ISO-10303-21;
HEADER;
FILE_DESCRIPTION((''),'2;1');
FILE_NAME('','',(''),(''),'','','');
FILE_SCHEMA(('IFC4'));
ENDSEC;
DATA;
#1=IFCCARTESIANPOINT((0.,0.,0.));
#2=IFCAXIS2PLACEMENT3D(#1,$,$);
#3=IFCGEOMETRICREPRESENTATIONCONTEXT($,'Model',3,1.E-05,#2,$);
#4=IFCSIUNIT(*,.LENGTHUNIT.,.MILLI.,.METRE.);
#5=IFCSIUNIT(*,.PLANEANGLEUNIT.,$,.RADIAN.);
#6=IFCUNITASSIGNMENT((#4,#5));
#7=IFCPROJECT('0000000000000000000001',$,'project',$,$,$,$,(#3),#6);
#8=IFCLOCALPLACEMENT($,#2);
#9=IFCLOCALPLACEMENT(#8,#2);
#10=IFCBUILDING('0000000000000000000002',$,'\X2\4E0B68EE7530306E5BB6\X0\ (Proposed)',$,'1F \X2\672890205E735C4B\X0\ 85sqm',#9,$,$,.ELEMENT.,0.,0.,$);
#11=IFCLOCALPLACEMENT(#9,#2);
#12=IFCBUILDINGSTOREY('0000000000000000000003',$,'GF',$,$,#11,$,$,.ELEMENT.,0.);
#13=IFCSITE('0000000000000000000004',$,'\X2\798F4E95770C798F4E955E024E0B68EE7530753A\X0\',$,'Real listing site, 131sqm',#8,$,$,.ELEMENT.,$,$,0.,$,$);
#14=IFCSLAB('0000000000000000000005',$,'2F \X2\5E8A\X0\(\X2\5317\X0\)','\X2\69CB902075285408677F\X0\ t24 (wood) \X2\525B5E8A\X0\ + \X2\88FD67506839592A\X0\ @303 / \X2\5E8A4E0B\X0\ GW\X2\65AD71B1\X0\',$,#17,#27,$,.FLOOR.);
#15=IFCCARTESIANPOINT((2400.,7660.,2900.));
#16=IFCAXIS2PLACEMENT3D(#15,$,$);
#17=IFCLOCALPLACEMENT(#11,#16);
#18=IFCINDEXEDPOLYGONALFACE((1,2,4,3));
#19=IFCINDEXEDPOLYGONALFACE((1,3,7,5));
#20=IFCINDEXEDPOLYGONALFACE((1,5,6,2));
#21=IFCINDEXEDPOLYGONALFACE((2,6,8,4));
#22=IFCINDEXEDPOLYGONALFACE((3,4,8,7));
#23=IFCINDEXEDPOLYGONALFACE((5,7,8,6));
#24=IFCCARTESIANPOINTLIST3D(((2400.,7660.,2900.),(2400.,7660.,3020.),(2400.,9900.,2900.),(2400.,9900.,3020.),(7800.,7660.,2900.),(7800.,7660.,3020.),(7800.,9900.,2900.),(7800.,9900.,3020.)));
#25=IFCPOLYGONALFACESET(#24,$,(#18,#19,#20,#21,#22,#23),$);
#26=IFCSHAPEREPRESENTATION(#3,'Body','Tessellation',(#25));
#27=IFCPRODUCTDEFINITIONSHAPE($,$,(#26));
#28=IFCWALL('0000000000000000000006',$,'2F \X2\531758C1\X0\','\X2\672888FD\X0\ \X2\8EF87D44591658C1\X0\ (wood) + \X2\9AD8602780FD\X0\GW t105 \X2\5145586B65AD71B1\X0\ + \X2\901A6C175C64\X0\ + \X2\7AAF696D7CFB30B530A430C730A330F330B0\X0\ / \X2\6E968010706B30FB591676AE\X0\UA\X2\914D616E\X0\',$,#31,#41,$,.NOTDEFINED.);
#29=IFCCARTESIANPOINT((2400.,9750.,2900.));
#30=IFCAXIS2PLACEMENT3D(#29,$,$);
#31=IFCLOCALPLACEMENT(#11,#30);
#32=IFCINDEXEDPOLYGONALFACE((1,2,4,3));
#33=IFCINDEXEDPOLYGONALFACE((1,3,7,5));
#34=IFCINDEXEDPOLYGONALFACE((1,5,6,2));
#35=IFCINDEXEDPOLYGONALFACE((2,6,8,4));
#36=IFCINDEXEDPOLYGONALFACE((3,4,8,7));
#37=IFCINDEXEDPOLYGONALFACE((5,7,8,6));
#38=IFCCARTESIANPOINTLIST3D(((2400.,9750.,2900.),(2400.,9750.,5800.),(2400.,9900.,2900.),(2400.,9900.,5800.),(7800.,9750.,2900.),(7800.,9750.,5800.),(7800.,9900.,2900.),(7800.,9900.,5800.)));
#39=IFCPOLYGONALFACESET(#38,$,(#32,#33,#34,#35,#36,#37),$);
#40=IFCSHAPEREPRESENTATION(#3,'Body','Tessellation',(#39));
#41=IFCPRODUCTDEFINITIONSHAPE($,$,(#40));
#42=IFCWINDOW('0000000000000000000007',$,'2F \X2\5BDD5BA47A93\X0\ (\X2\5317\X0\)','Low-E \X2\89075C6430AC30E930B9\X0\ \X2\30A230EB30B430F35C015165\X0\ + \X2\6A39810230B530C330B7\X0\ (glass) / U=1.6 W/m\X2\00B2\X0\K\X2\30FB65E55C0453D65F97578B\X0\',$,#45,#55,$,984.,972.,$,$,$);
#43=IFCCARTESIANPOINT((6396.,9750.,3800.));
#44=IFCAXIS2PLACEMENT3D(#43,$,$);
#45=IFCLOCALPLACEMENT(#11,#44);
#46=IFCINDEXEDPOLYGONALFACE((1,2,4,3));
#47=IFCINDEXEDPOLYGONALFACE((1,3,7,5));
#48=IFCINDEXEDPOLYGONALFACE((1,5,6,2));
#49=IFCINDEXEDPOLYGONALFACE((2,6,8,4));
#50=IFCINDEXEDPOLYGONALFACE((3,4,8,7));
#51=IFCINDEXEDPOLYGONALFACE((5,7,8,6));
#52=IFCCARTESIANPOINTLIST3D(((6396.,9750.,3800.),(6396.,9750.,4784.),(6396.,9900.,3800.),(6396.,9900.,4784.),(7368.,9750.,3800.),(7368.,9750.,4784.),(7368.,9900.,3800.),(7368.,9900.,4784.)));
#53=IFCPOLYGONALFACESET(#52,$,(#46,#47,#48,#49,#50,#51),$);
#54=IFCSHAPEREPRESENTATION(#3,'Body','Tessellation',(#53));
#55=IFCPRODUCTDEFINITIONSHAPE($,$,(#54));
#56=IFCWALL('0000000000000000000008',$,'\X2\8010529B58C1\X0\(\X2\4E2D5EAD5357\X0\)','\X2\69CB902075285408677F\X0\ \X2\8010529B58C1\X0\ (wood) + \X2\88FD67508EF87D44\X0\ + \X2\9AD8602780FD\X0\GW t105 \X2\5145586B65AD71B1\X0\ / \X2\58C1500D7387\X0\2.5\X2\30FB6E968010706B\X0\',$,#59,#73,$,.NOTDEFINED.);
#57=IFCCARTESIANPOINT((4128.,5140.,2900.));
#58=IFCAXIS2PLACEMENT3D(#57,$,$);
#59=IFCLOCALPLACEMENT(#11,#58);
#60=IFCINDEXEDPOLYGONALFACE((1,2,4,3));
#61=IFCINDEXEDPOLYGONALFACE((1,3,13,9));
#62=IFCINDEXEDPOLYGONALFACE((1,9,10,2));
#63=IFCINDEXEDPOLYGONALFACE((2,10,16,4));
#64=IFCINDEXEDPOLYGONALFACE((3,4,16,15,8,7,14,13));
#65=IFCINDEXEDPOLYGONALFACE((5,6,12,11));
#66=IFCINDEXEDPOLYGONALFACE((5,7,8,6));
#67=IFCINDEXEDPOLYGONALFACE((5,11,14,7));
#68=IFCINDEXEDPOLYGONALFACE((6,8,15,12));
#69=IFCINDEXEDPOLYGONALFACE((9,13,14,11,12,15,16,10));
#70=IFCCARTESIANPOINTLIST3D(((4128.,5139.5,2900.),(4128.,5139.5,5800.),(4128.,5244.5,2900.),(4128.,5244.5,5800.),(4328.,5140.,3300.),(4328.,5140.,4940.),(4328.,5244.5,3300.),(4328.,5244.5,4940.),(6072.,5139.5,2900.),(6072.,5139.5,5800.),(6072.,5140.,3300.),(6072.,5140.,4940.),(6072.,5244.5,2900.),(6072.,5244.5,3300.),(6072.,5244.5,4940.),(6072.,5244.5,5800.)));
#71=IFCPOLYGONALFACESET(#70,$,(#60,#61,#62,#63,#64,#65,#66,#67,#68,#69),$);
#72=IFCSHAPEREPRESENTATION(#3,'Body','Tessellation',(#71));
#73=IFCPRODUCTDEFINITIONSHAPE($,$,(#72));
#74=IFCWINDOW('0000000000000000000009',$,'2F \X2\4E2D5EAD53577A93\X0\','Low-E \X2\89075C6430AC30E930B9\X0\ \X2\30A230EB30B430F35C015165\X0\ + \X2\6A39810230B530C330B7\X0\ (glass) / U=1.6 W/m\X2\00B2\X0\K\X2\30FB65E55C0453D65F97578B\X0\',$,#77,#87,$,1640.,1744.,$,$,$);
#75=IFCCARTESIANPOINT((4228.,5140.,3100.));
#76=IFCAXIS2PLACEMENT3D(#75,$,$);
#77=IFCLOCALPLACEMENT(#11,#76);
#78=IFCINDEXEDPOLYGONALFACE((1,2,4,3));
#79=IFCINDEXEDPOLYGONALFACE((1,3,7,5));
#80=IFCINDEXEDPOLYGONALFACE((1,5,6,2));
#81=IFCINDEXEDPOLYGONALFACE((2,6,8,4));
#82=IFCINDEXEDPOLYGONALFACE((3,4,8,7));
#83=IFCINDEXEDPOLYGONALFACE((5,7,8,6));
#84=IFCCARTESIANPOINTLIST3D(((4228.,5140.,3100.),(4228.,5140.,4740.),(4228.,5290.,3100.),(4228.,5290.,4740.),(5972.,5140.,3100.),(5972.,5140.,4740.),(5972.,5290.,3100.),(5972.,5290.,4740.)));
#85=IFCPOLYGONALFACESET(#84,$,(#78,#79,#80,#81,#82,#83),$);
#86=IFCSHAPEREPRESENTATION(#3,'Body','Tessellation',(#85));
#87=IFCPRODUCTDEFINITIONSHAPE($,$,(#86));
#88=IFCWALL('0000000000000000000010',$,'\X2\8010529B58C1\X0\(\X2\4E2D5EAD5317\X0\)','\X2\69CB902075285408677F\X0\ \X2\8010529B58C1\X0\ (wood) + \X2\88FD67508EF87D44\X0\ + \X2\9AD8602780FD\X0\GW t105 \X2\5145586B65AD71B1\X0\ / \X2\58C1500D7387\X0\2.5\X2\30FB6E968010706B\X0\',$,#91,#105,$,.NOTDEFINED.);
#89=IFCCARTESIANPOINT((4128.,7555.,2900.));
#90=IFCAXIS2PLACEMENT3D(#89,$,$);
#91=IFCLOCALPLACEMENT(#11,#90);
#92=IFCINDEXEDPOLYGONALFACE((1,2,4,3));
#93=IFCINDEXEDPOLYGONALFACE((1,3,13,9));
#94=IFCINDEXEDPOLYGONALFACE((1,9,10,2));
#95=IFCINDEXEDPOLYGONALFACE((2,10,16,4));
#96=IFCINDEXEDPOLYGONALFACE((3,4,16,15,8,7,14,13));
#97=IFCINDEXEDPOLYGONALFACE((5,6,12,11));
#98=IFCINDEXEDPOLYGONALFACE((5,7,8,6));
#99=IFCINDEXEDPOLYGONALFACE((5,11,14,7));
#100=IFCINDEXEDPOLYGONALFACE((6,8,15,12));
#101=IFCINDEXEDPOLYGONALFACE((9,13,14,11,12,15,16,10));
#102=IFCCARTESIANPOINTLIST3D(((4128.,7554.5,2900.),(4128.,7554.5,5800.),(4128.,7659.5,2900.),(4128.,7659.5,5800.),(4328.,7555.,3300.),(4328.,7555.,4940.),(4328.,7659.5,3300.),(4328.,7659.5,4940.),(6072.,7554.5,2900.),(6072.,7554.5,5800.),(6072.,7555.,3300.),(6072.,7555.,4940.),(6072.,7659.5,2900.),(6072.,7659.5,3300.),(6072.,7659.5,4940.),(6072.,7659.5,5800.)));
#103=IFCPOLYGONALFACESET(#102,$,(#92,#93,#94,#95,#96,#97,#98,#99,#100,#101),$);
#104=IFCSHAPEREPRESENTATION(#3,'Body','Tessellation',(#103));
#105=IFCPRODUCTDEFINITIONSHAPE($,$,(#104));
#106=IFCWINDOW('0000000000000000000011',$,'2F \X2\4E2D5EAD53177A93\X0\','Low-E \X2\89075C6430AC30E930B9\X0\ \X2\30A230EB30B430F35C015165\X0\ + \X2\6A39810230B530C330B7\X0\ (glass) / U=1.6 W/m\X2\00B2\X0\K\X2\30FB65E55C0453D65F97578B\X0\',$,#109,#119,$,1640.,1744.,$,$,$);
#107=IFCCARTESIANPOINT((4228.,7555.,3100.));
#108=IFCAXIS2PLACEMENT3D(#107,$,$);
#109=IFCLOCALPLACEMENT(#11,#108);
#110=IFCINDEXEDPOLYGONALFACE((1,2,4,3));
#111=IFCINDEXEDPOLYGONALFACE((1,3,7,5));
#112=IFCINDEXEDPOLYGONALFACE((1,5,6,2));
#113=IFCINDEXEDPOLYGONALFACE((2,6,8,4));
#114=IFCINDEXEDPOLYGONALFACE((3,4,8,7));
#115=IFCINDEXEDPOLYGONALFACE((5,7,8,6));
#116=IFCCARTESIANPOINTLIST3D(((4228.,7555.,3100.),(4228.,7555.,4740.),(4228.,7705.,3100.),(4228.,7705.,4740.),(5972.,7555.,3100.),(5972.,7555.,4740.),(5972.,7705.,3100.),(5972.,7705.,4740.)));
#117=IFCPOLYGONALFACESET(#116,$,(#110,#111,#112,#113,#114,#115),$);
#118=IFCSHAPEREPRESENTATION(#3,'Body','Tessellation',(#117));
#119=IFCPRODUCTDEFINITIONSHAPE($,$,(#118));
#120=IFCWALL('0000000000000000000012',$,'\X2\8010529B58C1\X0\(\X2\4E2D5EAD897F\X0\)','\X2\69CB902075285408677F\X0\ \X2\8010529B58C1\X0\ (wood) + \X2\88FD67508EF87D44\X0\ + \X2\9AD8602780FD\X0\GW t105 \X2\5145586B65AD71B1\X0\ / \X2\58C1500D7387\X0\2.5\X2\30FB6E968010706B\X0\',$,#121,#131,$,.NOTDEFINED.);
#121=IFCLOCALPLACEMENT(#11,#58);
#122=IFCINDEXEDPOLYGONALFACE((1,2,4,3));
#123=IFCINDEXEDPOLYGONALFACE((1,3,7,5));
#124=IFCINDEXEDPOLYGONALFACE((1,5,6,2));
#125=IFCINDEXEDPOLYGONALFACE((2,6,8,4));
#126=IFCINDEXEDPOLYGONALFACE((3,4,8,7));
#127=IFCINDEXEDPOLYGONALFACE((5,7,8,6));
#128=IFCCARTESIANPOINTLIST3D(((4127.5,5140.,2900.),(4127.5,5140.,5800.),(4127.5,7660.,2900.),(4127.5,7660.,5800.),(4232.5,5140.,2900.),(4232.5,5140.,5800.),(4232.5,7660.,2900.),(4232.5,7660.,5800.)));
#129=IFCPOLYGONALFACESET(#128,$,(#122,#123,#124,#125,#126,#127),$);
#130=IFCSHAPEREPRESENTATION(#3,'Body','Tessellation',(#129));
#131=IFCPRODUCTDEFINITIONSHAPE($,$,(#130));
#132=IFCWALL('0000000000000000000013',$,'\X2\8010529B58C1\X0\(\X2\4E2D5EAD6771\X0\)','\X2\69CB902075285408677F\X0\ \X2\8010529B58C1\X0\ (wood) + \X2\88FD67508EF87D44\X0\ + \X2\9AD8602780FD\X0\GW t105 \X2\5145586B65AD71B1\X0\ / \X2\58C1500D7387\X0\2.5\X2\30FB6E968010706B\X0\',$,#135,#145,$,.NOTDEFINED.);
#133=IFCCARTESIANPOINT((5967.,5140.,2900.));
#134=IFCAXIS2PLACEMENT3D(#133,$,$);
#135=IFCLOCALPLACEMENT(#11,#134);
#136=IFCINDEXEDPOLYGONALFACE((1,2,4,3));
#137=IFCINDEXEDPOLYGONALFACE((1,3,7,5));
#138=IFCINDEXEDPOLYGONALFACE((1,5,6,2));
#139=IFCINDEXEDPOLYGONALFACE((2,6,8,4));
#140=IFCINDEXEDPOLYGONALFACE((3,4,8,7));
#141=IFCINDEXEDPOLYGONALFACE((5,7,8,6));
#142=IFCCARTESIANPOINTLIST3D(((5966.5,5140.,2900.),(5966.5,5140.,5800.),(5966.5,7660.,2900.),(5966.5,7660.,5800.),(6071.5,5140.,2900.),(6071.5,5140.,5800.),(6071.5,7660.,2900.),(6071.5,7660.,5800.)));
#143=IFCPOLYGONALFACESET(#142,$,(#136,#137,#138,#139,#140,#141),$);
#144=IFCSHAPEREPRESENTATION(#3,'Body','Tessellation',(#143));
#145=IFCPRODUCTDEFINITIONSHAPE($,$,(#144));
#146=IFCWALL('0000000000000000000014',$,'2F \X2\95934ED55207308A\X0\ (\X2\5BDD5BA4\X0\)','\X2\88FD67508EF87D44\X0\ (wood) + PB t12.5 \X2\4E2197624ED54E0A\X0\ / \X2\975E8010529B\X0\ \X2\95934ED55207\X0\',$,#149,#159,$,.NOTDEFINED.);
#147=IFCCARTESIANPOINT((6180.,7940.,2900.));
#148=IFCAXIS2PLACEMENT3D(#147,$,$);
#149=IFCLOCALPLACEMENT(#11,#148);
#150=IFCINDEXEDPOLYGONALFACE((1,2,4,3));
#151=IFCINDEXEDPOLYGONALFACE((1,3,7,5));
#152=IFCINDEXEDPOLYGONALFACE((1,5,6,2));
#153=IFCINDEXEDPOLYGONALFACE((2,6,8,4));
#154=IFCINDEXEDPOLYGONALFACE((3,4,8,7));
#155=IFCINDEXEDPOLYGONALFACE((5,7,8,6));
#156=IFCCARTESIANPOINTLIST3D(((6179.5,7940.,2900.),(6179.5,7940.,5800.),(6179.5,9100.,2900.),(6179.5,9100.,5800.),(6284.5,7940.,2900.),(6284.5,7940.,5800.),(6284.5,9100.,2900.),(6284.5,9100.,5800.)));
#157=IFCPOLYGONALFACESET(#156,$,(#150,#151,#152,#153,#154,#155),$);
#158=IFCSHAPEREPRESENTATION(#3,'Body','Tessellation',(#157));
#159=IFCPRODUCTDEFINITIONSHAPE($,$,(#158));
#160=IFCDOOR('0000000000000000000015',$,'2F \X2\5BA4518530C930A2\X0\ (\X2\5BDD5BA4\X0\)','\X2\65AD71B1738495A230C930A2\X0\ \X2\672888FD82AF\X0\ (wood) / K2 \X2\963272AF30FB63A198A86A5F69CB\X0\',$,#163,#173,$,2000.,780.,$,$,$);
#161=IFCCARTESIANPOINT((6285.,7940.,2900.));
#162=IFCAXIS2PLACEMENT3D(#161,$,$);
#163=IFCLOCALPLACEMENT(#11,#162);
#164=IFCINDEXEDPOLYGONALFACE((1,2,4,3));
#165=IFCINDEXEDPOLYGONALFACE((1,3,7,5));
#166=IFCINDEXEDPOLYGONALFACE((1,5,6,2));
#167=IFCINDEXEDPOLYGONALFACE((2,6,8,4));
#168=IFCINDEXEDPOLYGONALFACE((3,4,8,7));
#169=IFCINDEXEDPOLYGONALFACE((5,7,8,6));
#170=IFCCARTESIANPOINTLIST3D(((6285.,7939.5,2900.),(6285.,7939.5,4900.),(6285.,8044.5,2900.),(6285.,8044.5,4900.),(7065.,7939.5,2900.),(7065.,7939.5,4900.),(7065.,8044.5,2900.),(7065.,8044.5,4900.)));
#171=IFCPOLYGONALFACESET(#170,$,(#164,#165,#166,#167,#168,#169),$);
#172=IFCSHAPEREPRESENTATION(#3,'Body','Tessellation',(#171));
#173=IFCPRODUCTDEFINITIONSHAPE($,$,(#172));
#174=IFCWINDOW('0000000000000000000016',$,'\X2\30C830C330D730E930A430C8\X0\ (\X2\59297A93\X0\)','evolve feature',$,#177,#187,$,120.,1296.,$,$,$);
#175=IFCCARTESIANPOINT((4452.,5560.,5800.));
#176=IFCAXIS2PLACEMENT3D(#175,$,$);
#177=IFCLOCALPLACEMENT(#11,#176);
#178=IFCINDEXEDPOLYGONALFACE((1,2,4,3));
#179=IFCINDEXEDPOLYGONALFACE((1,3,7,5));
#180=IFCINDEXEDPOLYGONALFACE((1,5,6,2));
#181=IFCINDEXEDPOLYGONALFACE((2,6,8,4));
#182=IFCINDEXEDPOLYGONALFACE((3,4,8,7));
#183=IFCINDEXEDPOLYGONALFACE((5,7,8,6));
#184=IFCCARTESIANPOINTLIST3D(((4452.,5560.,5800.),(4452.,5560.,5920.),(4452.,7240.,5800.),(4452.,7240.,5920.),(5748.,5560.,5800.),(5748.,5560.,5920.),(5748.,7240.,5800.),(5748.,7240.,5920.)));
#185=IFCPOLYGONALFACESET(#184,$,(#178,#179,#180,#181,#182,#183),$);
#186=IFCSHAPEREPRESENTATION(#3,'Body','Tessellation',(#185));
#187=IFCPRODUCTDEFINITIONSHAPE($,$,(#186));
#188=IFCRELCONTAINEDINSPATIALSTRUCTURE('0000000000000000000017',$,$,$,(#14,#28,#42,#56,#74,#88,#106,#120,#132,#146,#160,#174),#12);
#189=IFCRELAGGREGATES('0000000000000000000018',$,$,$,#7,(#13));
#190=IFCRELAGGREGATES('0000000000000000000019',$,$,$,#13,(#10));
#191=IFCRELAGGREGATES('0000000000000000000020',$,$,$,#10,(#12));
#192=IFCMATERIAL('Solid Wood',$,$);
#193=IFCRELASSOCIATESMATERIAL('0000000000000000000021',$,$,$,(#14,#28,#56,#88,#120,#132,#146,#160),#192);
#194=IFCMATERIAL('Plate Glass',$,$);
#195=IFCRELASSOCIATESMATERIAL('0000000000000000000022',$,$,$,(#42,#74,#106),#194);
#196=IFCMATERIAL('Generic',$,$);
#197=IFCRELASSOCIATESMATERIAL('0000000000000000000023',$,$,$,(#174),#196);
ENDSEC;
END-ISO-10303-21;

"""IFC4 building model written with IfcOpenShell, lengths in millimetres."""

from ifc_helpers import new_model, si_unit, frame, frame_2d, origin, place, context, project, spatial, rectangle, extrude, material, element, fill, save


model = new_model("IFC4")

# Units and contexts
model_context = context("Model", 3, precision=1e-05, world=origin())
ifc_project = project(units=[si_unit("LENGTHUNIT", "METRE", prefix="MILLI"), si_unit("PLANEANGLEUNIT", "RADIAN")], contexts=[model_context])

# Site, building, storey
site_placement = place(None, origin())
site = spatial("IfcSite", under=ifc_project, at=site_placement, Name="福井県福井市下森田町", ObjectType="Real listing site, 131sqm", CompositionType="ELEMENT", RefElevation=0.0)
building_placement = place(site_placement, origin())
building = spatial("IfcBuilding", under=site, at=building_placement, Name="下森田の家 (Proposed)", ObjectType="1F 木造平屋 85sqm", CompositionType="ELEMENT", ElevationOfRefHeight=0.0, ElevationOfTerrain=0.0)
storey_placement = place(building_placement, origin())
storey = spatial("IfcBuildingStorey", under=building, at=storey_placement, Name="GF", CompositionType="ELEMENT", Elevation=0.0)

# Slab
ifc_material_1 = material(Name="Solid Wood")
slab_placement = place(storey_placement, frame((2400.0, 7660.0, 2900.0)))
element("IfcSlab", 1, at=slab_placement, inside=storey, material=ifc_material_1, Name="2F 床(北)", Description="構造用合板 t24 (wood) 剛床 + 製材根太 @303 / 床下 GW断熱", PredefinedType="FLOOR", context=model_context, shape_type="SweptSolid", body=[
    extrude(rectangle(XDim=5400.0, YDim=2240.0, at=frame_2d((2700.0, 1120.0))), frame((2400.0, 7660.0, 2900.0)), (0.0, 0.0, 1.0), 120.0),
])

# Walls, openings, windows
wall_1_placement = place(storey_placement, frame((2400.0, 9750.0, 2900.0)))
wall_1 = element("IfcWall", 2, at=wall_1_placement, inside=storey, material=ifc_material_1, Name="2F 北壁", Description="木製 軸組外壁 (wood) + 高性能GW t105 充填断熱 + 通気層 + 窯業系サイディング / 準耐火・外皮UA配慮", PredefinedType="NOTDEFINED", context=model_context, shape_type="SweptSolid", body=[
    extrude(rectangle(XDim=5400.0, YDim=150.0, at=frame_2d((2700.0, 75.0))), frame((2400.0, 9750.0, 2900.0)), (0.0, 0.0, 1.0), 2900.0),
])
opening_1_placement = place(storey_placement, frame((6396.0, 9750.0, 3800.0)))
opening_1 = element("IfcOpeningElement", 3, at=opening_1_placement, cuts=wall_1, PredefinedType="NOTDEFINED", context=model_context, shape_type="SweptSolid", body=[
    extrude(rectangle(XDim=972.0, YDim=150.0, at=frame_2d((486.0, 75.0))), frame((6396.0, 9750.0, 3800.0)), (0.0, 0.0, 1.0), 984.0),
])
ifc_material_2 = material(Name="Plate Glass")
window_1_placement = place(storey_placement, frame((6396.0, 9750.0, 3800.0)))
window_1 = element("IfcWindow", 4, at=window_1_placement, inside=storey, material=ifc_material_2, Name="2F 寝室窓 (北)", Description="Low-E 複層ガラス アルゴン封入 + 樹脂サッシ (glass) / U=1.6 W/m²K・日射取得型", OverallHeight=984.0, OverallWidth=972.0, context=model_context, shape_type="SweptSolid", body=[
    extrude(rectangle(XDim=972.0, YDim=150.0, at=frame_2d((486.0, 75.0))), frame((6396.0, 9750.0, 3800.0)), (0.0, 0.0, 1.0), 984.0),
])
fill(opening_1, window_1)
wall_2_placement = place(storey_placement, frame((4128.0, 5140.0, 2900.0)))
wall_2 = element("IfcWall", 5, at=wall_2_placement, inside=storey, material=ifc_material_1, Name="耐力壁(中庭南)", Description="構造用合板 耐力壁 (wood) + 製材軸組 + 高性能GW t105 充填断熱 / 壁倍率2.5・準耐火", PredefinedType="NOTDEFINED", context=model_context, shape_type="SweptSolid", body=[
    extrude(rectangle(XDim=1944.0, YDim=105.0, at=frame_2d((972.0, 52.0))), frame((4128.0, 5140.0, 2900.0)), (0.0, 0.0, 1.0), 2900.0),
])
opening_2_placement = place(storey_placement, frame((4228.0, 5140.0, 3100.0)))
opening_2 = element("IfcOpeningElement", 6, at=opening_2_placement, cuts=wall_2, PredefinedType="NOTDEFINED", context=model_context, shape_type="SweptSolid", body=[
    extrude(rectangle(XDim=1744.0, YDim=150.0, at=frame_2d((872.0, 75.0))), frame((4228.0, 5140.0, 3100.0)), (0.0, 0.0, 1.0), 1640.0),
])
window_2_placement = place(storey_placement, frame((4228.0, 5140.0, 3100.0)))
window_2 = element("IfcWindow", 7, at=window_2_placement, inside=storey, material=ifc_material_2, Name="2F 中庭南窓", Description="Low-E 複層ガラス アルゴン封入 + 樹脂サッシ (glass) / U=1.6 W/m²K・日射取得型", OverallHeight=1640.0, OverallWidth=1744.0, context=model_context, shape_type="SweptSolid", body=[
    extrude(rectangle(XDim=1744.0, YDim=150.0, at=frame_2d((872.0, 75.0))), frame((4228.0, 5140.0, 3100.0)), (0.0, 0.0, 1.0), 1640.0),
])
fill(opening_2, window_2)
wall_3_placement = place(storey_placement, frame((4128.0, 7555.0, 2900.0)))
wall_3 = element("IfcWall", 8, at=wall_3_placement, inside=storey, material=ifc_material_1, Name="耐力壁(中庭北)", Description="構造用合板 耐力壁 (wood) + 製材軸組 + 高性能GW t105 充填断熱 / 壁倍率2.5・準耐火", PredefinedType="NOTDEFINED", context=model_context, shape_type="SweptSolid", body=[
    extrude(rectangle(XDim=1944.0, YDim=105.0, at=frame_2d((972.0, 52.0))), frame((4128.0, 7555.0, 2900.0)), (0.0, 0.0, 1.0), 2900.0),
])
opening_3_placement = place(storey_placement, frame((4228.0, 7555.0, 3100.0)))
opening_3 = element("IfcOpeningElement", 9, at=opening_3_placement, cuts=wall_3, PredefinedType="NOTDEFINED", context=model_context, shape_type="SweptSolid", body=[
    extrude(rectangle(XDim=1744.0, YDim=150.0, at=frame_2d((872.0, 75.0))), frame((4228.0, 7555.0, 3100.0)), (0.0, 0.0, 1.0), 1640.0),
])
window_3_placement = place(storey_placement, frame((4228.0, 7555.0, 3100.0)))
window_3 = element("IfcWindow", 10, at=window_3_placement, inside=storey, material=ifc_material_2, Name="2F 中庭北窓", Description="Low-E 複層ガラス アルゴン封入 + 樹脂サッシ (glass) / U=1.6 W/m²K・日射取得型", OverallHeight=1640.0, OverallWidth=1744.0, context=model_context, shape_type="SweptSolid", body=[
    extrude(rectangle(XDim=1744.0, YDim=150.0, at=frame_2d((872.0, 75.0))), frame((4228.0, 7555.0, 3100.0)), (0.0, 0.0, 1.0), 1640.0),
])
fill(opening_3, window_3)

# Walls
wall_4_placement = place(storey_placement, frame((4128.0, 5140.0, 2900.0)))
element("IfcWall", 11, at=wall_4_placement, inside=storey, material=ifc_material_1, Name="耐力壁(中庭西)", Description="構造用合板 耐力壁 (wood) + 製材軸組 + 高性能GW t105 充填断熱 / 壁倍率2.5・準耐火", PredefinedType="NOTDEFINED", context=model_context, shape_type="SweptSolid", body=[
    extrude(rectangle(XDim=105.0, YDim=2520.0, at=frame_2d((52.0, 1260.0))), frame((4128.0, 5140.0, 2900.0)), (0.0, 0.0, 1.0), 2900.0),
])
wall_5_placement = place(storey_placement, frame((5967.0, 5140.0, 2900.0)))
element("IfcWall", 12, at=wall_5_placement, inside=storey, material=ifc_material_1, Name="耐力壁(中庭東)", Description="構造用合板 耐力壁 (wood) + 製材軸組 + 高性能GW t105 充填断熱 / 壁倍率2.5・準耐火", PredefinedType="NOTDEFINED", context=model_context, shape_type="SweptSolid", body=[
    extrude(rectangle(XDim=105.0, YDim=2520.0, at=frame_2d((52.0, 1260.0))), frame((5967.0, 5140.0, 2900.0)), (0.0, 0.0, 1.0), 2900.0),
])
wall_6_placement = place(storey_placement, frame((6180.0, 7940.0, 2900.0)))
element("IfcWall", 13, at=wall_6_placement, inside=storey, material=ifc_material_1, Name="2F 間仕切り (寝室)", Description="製材軸組 (wood) + PB t12.5 両面仕上 / 非耐力 間仕切", PredefinedType="NOTDEFINED", context=model_context, shape_type="SweptSolid", body=[
    extrude(rectangle(XDim=105.0, YDim=1160.0, at=frame_2d((52.0, 580.0))), frame((6180.0, 7940.0, 2900.0)), (0.0, 0.0, 1.0), 2900.0),
])

# Door
door_placement = place(storey_placement, frame((6285.0, 7940.0, 2900.0)))
element("IfcDoor", 14, at=door_placement, inside=storey, material=ifc_material_1, Name="2F 室内ドア (寝室)", Description="断熱玄関ドア 木製芯 (wood) / K2 防犯・採風機構", OverallHeight=2000.0, OverallWidth=780.0, context=model_context, shape_type="SweptSolid", body=[
    extrude(rectangle(XDim=780.0, YDim=105.0, at=frame_2d((390.0, 52.0))), frame((6285.0, 7940.0, 2900.0)), (0.0, 0.0, 1.0), 2000.0),
])

# Window
ifc_material_3 = material(Name="Generic")
window_4_placement = place(storey_placement, frame((4452.0, 5560.0, 5800.0)))
element("IfcWindow", 15, at=window_4_placement, inside=storey, material=ifc_material_3, Name="トップライト (天窓)", Description="evolve feature", OverallHeight=120.0, OverallWidth=1296.0, context=model_context, shape_type="SweptSolid", body=[
    extrude(rectangle(XDim=1296.0, YDim=1680.0, at=frame_2d((648.0, 840.0))), frame((4452.0, 5560.0, 5800.0)), (0.0, 0.0, 1.0), 120.0),
])

save(model, "model.ifc")
